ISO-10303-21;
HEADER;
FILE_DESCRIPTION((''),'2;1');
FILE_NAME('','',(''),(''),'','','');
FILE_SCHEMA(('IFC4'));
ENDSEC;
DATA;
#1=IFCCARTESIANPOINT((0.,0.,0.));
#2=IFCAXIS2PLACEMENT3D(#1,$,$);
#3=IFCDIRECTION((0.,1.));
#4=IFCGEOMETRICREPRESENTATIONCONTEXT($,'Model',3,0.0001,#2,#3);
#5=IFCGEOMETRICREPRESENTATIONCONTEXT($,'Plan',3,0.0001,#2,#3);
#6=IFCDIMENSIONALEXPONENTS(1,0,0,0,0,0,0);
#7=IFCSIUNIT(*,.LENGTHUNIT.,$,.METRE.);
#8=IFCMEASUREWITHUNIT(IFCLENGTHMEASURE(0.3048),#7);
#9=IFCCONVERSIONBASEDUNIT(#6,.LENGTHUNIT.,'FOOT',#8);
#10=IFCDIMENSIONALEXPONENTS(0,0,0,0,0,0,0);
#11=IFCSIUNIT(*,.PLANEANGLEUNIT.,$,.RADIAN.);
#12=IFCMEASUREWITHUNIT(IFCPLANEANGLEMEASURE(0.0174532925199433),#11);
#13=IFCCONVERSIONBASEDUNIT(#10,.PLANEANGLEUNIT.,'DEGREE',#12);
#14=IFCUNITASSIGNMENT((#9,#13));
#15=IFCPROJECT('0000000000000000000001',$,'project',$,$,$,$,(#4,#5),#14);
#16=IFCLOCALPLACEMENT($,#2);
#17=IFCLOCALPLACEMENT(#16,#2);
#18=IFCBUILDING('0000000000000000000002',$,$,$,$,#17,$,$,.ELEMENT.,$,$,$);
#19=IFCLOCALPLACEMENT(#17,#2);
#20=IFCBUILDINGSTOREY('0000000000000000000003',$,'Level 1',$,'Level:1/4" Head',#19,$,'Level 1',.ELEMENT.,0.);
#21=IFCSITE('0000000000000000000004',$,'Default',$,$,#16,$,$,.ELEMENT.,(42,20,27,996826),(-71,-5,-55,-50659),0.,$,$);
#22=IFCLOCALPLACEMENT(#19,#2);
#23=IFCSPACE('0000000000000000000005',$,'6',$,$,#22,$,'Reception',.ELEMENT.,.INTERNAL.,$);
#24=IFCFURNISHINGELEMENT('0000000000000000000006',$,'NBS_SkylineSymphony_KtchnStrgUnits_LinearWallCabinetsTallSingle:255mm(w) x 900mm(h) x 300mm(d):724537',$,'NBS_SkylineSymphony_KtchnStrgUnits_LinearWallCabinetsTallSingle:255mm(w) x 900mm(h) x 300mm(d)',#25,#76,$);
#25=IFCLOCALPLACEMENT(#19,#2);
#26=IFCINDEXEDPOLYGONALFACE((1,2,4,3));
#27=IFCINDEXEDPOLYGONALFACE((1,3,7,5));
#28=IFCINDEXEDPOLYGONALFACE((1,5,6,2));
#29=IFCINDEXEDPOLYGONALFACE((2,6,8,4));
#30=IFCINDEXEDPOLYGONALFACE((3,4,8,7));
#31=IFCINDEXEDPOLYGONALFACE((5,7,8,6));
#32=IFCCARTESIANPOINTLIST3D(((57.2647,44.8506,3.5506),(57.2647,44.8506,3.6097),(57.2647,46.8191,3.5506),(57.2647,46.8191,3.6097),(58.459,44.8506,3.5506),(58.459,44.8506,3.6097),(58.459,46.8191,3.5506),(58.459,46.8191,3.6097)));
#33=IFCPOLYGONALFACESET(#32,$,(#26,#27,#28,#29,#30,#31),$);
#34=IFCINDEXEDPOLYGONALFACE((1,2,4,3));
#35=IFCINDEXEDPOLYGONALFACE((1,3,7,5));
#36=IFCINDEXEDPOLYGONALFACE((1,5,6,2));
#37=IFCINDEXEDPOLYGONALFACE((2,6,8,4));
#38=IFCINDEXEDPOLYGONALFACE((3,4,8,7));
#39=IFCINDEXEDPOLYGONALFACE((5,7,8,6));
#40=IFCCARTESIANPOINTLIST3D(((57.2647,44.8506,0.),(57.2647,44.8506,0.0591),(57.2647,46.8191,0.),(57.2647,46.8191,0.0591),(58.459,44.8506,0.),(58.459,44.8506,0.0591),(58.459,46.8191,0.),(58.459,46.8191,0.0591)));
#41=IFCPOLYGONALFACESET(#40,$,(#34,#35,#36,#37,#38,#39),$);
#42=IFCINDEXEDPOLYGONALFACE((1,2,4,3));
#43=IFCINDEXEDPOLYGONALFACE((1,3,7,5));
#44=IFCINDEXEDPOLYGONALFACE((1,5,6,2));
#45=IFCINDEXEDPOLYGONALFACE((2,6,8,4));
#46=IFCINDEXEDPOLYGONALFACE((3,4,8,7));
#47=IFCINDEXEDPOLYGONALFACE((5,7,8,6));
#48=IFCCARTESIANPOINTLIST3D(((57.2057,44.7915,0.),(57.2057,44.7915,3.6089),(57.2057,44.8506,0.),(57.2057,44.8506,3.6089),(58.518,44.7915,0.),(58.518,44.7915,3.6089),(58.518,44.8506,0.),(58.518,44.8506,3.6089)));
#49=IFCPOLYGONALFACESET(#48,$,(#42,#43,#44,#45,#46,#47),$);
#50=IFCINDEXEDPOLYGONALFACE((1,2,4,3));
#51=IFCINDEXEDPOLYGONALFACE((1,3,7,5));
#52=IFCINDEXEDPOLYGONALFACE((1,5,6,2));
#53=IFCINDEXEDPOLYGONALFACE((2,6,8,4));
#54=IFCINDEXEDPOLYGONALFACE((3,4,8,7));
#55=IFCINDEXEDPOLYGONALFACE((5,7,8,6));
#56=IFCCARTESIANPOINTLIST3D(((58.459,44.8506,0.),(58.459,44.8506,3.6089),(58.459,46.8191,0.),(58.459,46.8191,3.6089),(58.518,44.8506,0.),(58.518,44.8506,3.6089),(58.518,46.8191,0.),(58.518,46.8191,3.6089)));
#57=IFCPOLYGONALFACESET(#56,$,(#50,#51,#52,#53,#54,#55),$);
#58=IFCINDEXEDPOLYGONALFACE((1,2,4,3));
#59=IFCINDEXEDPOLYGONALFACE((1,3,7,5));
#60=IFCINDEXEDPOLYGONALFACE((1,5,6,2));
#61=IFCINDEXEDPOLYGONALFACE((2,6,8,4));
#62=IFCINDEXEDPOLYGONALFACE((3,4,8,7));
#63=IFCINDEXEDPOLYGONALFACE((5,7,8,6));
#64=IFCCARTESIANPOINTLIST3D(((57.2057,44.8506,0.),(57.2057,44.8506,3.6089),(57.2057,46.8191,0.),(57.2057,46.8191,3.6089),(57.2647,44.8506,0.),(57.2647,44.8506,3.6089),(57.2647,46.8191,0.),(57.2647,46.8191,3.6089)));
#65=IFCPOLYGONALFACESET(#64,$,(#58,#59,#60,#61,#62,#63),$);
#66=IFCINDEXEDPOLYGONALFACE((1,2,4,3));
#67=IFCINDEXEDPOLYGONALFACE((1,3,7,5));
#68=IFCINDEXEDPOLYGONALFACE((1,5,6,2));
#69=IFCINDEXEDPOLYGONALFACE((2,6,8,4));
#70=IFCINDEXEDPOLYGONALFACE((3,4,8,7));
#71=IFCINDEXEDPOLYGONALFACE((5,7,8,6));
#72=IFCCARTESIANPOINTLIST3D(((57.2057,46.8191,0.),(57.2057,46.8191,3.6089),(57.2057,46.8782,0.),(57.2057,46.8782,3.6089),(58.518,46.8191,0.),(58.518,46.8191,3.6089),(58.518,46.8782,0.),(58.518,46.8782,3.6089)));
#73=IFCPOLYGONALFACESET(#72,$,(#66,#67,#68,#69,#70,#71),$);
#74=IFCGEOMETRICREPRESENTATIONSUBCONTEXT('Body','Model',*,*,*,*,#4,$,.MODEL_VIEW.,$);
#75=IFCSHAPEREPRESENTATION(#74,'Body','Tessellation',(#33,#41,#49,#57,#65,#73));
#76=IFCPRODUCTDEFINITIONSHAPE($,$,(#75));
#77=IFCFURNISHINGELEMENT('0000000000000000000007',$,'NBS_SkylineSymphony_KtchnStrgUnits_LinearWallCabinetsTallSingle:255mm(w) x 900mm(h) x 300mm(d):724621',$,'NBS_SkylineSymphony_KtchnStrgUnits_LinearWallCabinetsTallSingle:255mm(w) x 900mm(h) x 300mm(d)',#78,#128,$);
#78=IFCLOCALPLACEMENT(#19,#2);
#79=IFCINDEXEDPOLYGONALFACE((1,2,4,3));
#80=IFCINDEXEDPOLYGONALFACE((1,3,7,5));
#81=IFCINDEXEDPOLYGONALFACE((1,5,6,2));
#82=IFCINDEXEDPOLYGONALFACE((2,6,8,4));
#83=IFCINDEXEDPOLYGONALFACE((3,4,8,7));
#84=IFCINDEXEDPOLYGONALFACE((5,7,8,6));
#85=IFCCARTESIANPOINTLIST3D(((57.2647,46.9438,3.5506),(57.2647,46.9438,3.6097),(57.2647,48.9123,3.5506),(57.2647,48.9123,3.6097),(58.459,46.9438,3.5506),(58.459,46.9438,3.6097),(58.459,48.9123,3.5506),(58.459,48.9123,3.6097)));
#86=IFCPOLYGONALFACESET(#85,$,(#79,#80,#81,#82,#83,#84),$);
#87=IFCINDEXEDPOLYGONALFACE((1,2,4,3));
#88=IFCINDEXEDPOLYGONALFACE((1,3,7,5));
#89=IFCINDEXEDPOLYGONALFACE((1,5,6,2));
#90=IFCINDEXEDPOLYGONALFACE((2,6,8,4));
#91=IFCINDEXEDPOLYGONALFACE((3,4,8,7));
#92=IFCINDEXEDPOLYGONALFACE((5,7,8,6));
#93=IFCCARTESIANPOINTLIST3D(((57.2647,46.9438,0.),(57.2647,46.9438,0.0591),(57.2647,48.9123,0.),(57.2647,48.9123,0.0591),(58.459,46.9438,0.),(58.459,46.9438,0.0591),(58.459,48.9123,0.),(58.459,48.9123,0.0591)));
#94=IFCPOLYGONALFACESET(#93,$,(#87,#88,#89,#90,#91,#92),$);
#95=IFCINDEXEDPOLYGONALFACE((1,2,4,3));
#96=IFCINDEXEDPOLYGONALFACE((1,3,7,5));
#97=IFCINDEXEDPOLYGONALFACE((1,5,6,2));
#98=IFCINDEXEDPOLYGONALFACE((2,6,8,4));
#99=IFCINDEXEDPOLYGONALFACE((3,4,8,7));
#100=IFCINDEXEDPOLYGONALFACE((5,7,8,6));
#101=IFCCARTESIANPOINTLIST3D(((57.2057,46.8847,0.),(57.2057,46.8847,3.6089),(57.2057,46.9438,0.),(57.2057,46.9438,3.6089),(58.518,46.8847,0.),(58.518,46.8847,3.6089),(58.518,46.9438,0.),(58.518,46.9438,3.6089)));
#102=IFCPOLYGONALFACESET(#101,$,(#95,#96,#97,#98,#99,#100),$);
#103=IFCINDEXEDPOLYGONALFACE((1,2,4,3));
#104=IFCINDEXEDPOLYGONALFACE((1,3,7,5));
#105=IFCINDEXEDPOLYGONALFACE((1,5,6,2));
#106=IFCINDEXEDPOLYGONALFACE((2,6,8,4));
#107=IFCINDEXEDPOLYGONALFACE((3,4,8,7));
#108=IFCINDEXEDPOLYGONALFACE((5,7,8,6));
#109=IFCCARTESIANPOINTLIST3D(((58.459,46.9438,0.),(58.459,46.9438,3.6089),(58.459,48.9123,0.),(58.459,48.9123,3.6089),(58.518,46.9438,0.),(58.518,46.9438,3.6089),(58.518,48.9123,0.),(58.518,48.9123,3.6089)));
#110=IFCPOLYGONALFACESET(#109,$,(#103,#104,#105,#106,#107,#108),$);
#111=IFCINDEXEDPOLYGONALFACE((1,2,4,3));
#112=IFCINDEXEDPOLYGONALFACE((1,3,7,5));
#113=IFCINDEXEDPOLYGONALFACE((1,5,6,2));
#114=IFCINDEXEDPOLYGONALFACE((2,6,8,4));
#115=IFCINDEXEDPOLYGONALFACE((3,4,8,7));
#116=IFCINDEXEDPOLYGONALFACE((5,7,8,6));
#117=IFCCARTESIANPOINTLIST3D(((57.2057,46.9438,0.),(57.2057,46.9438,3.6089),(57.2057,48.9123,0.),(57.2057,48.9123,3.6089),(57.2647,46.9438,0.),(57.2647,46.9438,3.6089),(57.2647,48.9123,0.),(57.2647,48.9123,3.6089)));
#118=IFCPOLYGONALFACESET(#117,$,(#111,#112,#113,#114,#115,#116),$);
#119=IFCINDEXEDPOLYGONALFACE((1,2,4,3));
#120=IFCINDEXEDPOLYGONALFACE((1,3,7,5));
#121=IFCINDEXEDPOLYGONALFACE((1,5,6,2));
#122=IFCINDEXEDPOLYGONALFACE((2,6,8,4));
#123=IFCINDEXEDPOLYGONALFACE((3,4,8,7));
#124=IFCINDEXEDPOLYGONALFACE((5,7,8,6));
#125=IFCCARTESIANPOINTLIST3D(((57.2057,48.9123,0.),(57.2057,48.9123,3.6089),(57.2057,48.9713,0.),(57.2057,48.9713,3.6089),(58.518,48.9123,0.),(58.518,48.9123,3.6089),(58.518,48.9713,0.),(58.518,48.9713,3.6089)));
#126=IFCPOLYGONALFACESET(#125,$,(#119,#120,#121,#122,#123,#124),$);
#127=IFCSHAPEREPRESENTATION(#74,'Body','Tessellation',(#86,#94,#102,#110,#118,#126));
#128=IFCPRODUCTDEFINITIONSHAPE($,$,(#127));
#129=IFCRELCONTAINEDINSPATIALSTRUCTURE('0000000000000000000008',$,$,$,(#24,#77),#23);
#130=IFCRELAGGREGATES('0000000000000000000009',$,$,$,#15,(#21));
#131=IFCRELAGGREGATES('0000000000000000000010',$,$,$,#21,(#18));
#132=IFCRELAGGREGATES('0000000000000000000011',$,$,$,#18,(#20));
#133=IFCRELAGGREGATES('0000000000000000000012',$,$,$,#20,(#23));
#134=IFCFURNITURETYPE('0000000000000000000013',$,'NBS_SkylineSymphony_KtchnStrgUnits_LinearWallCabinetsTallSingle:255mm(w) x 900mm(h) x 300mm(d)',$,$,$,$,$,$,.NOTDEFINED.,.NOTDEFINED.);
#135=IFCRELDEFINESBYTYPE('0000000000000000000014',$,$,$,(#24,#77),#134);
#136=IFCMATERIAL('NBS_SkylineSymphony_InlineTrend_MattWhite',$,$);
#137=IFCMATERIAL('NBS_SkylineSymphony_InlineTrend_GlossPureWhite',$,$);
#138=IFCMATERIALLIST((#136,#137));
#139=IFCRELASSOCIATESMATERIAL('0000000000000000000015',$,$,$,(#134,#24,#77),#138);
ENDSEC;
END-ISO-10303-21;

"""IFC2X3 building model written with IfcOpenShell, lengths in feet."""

from ifc_helpers import new_model, entity, si_unit, converted_unit, direction, frame, frame_2d, origin, origin_2d_with_axis, place, context, subcontext, project, spatial, rectangle, extrude, source, transform, mapped, material, material_list, type_object, type_shapes, element, save


model = new_model("IFC2X3")

# Units and contexts
model_context = context("Model", 3, precision=0.0001, world=origin(), true_north=direction((0.0, 1.0)))
plan_context = context("Plan", 3, precision=0.0001, world=origin(), true_north=direction((0.0, 1.0)))
body_context = subcontext(model_context, "Body", "Model", "MODEL_VIEW")
ifc_project = project(units=[converted_unit("LENGTHUNIT", "FOOT", entity("IfcLengthMeasure", 0.3048), si_unit("LENGTHUNIT", "METRE"), dimensions=[1, 0, 0, 0, 0, 0, 0]), converted_unit("PLANEANGLEUNIT", "DEGREE", entity("IfcPlaneAngleMeasure", 0.0174532925199433), si_unit("PLANEANGLEUNIT", "RADIAN"), dimensions=[0, 0, 0, 0, 0, 0, 0])], contexts=[model_context, plan_context])

# Site, building, storey
site_placement = place(None, origin())
site = spatial("IfcSite", under=ifc_project, at=site_placement, Name="Default", CompositionType="ELEMENT", RefLatitude=(42, 20, 27, 996826), RefLongitude=(-71, -5, -55, -50659), RefElevation=0.0)
building_placement = place(site_placement, origin())
building = spatial("IfcBuilding", under=site, at=building_placement, CompositionType="ELEMENT")
storey_placement = place(building_placement, origin())
storey = spatial("IfcBuildingStorey", under=building, at=storey_placement, Name="Level 1", ObjectType="Level:1/4\" Head", LongName="Level 1", CompositionType="ELEMENT", Elevation=0.0)

# Shared definitions
space_1_placement = place(storey_placement, origin())
space_1 = spatial("IfcSpace", under=storey, at=space_1_placement, Name="6", LongName="Reception", CompositionType="ELEMENT", InteriorOrExteriorSpace="INTERNAL")

# Furnishing elements
ifc_material_1 = material(Name="NBS_SkylineSymphony_InlineTrend_MattWhite")
ifc_material_2 = material(Name="NBS_SkylineSymphony_InlineTrend_GlossPureWhite")
ifc_material_list = material_list([ifc_material_1, ifc_material_2])
furniture_type = type_object("IfcFurnitureType", Name="NBS_SkylineSymphony_KtchnStrgUnits_LinearWallCabinetsTallSingle:255mm(w) x 900mm(h) x 300mm(d)", AssemblyPlace="NOTDEFINED", material=ifc_material_list)
shared_shape_1 = source(origin(), body_context, "Body", "SweptSolid", [
    extrude(rectangle(XDim=1.9685, YDim=1.1942, at=origin_2d_with_axis()), frame((-0.2379, 0.0, 3.5506), z_axis=(0.0, 0.0, 1.0), x_axis=(0.0, 1.0, 0.0)), (0.0, 0.0, 1.0), 0.0591),
    extrude(rectangle(XDim=1.9685, YDim=1.1942, at=origin_2d_with_axis()), frame((-0.2379, 0.0, 0.0), z_axis=(0.0, 0.0, 1.0), x_axis=(0.0, 1.0, 0.0)), (0.0, 0.0, 1.0), 0.0591),
    extrude(rectangle(XDim=1.3123, YDim=0.0591, at=origin_2d_with_axis()), frame((-0.2379, 1.0138, 0.0), z_axis=(0.0, 0.0, 1.0), x_axis=(-1.0, 0.0, 0.0)), (0.0, 0.0, 1.0), 3.6089),
    extrude(rectangle(XDim=1.9685, YDim=0.0591, at=origin_2d_with_axis()), frame((-0.8645, 0.0, 0.0), z_axis=(0.0, 0.0, 1.0), x_axis=(0.0, -1.0, 0.0)), (0.0, 0.0, 1.0), 3.6089),
    extrude(rectangle(XDim=0.0591, YDim=1.9685, at=origin_2d_with_axis()), frame((0.3888, 0.0, 0.0)), (0.0, 0.0, 1.0), 3.6089),
    extrude(rectangle(XDim=0.0591, YDim=1.3123, at=frame_2d((0.0, 0.0), x_axis=(1.0, 0.0))), frame((-0.2379, -1.0138, 0.0), z_axis=(0.0, 0.0, 1.0), x_axis=(0.0, 1.0, 0.0)), (0.0, 0.0, 1.0), 3.6089),
])
type_shapes(furniture_type, [shared_shape_1])
for number, where, z_axis, x_axis, name in (
    (1, (57.624, 45.8348, 0.0), (0.0, 0.0, 1.0), (-1.0, 0.0, 0.0), "NBS_SkylineSymphony_KtchnStrgUnits_LinearWallCabinetsTallSingle:255mm(w) x 900mm(h) x 300mm(d):724537"),
    (2, (57.624, 47.928, 0.0), (0.0, 0.0, 1.0), (-1.0, 0.0, 0.0), "NBS_SkylineSymphony_KtchnStrgUnits_LinearWallCabinetsTallSingle:255mm(w) x 900mm(h) x 300mm(d):724621"),
):
    element("IfcFurnishingElement", number, at=place(space_1_placement, frame(where, z_axis=z_axis, x_axis=x_axis)), inside=space_1, type_object=furniture_type, material=ifc_material_list, Name=name, ObjectType="NBS_SkylineSymphony_KtchnStrgUnits_LinearWallCabinetsTallSingle:255mm(w) x 900mm(h) x 300mm(d)", context=body_context, shape_type="MappedRepresentation", body=[
        mapped(shared_shape_1, transform((0.0, 0.0, 0.0), scale=1.0)),
    ])

save(model, "model.ifc")
